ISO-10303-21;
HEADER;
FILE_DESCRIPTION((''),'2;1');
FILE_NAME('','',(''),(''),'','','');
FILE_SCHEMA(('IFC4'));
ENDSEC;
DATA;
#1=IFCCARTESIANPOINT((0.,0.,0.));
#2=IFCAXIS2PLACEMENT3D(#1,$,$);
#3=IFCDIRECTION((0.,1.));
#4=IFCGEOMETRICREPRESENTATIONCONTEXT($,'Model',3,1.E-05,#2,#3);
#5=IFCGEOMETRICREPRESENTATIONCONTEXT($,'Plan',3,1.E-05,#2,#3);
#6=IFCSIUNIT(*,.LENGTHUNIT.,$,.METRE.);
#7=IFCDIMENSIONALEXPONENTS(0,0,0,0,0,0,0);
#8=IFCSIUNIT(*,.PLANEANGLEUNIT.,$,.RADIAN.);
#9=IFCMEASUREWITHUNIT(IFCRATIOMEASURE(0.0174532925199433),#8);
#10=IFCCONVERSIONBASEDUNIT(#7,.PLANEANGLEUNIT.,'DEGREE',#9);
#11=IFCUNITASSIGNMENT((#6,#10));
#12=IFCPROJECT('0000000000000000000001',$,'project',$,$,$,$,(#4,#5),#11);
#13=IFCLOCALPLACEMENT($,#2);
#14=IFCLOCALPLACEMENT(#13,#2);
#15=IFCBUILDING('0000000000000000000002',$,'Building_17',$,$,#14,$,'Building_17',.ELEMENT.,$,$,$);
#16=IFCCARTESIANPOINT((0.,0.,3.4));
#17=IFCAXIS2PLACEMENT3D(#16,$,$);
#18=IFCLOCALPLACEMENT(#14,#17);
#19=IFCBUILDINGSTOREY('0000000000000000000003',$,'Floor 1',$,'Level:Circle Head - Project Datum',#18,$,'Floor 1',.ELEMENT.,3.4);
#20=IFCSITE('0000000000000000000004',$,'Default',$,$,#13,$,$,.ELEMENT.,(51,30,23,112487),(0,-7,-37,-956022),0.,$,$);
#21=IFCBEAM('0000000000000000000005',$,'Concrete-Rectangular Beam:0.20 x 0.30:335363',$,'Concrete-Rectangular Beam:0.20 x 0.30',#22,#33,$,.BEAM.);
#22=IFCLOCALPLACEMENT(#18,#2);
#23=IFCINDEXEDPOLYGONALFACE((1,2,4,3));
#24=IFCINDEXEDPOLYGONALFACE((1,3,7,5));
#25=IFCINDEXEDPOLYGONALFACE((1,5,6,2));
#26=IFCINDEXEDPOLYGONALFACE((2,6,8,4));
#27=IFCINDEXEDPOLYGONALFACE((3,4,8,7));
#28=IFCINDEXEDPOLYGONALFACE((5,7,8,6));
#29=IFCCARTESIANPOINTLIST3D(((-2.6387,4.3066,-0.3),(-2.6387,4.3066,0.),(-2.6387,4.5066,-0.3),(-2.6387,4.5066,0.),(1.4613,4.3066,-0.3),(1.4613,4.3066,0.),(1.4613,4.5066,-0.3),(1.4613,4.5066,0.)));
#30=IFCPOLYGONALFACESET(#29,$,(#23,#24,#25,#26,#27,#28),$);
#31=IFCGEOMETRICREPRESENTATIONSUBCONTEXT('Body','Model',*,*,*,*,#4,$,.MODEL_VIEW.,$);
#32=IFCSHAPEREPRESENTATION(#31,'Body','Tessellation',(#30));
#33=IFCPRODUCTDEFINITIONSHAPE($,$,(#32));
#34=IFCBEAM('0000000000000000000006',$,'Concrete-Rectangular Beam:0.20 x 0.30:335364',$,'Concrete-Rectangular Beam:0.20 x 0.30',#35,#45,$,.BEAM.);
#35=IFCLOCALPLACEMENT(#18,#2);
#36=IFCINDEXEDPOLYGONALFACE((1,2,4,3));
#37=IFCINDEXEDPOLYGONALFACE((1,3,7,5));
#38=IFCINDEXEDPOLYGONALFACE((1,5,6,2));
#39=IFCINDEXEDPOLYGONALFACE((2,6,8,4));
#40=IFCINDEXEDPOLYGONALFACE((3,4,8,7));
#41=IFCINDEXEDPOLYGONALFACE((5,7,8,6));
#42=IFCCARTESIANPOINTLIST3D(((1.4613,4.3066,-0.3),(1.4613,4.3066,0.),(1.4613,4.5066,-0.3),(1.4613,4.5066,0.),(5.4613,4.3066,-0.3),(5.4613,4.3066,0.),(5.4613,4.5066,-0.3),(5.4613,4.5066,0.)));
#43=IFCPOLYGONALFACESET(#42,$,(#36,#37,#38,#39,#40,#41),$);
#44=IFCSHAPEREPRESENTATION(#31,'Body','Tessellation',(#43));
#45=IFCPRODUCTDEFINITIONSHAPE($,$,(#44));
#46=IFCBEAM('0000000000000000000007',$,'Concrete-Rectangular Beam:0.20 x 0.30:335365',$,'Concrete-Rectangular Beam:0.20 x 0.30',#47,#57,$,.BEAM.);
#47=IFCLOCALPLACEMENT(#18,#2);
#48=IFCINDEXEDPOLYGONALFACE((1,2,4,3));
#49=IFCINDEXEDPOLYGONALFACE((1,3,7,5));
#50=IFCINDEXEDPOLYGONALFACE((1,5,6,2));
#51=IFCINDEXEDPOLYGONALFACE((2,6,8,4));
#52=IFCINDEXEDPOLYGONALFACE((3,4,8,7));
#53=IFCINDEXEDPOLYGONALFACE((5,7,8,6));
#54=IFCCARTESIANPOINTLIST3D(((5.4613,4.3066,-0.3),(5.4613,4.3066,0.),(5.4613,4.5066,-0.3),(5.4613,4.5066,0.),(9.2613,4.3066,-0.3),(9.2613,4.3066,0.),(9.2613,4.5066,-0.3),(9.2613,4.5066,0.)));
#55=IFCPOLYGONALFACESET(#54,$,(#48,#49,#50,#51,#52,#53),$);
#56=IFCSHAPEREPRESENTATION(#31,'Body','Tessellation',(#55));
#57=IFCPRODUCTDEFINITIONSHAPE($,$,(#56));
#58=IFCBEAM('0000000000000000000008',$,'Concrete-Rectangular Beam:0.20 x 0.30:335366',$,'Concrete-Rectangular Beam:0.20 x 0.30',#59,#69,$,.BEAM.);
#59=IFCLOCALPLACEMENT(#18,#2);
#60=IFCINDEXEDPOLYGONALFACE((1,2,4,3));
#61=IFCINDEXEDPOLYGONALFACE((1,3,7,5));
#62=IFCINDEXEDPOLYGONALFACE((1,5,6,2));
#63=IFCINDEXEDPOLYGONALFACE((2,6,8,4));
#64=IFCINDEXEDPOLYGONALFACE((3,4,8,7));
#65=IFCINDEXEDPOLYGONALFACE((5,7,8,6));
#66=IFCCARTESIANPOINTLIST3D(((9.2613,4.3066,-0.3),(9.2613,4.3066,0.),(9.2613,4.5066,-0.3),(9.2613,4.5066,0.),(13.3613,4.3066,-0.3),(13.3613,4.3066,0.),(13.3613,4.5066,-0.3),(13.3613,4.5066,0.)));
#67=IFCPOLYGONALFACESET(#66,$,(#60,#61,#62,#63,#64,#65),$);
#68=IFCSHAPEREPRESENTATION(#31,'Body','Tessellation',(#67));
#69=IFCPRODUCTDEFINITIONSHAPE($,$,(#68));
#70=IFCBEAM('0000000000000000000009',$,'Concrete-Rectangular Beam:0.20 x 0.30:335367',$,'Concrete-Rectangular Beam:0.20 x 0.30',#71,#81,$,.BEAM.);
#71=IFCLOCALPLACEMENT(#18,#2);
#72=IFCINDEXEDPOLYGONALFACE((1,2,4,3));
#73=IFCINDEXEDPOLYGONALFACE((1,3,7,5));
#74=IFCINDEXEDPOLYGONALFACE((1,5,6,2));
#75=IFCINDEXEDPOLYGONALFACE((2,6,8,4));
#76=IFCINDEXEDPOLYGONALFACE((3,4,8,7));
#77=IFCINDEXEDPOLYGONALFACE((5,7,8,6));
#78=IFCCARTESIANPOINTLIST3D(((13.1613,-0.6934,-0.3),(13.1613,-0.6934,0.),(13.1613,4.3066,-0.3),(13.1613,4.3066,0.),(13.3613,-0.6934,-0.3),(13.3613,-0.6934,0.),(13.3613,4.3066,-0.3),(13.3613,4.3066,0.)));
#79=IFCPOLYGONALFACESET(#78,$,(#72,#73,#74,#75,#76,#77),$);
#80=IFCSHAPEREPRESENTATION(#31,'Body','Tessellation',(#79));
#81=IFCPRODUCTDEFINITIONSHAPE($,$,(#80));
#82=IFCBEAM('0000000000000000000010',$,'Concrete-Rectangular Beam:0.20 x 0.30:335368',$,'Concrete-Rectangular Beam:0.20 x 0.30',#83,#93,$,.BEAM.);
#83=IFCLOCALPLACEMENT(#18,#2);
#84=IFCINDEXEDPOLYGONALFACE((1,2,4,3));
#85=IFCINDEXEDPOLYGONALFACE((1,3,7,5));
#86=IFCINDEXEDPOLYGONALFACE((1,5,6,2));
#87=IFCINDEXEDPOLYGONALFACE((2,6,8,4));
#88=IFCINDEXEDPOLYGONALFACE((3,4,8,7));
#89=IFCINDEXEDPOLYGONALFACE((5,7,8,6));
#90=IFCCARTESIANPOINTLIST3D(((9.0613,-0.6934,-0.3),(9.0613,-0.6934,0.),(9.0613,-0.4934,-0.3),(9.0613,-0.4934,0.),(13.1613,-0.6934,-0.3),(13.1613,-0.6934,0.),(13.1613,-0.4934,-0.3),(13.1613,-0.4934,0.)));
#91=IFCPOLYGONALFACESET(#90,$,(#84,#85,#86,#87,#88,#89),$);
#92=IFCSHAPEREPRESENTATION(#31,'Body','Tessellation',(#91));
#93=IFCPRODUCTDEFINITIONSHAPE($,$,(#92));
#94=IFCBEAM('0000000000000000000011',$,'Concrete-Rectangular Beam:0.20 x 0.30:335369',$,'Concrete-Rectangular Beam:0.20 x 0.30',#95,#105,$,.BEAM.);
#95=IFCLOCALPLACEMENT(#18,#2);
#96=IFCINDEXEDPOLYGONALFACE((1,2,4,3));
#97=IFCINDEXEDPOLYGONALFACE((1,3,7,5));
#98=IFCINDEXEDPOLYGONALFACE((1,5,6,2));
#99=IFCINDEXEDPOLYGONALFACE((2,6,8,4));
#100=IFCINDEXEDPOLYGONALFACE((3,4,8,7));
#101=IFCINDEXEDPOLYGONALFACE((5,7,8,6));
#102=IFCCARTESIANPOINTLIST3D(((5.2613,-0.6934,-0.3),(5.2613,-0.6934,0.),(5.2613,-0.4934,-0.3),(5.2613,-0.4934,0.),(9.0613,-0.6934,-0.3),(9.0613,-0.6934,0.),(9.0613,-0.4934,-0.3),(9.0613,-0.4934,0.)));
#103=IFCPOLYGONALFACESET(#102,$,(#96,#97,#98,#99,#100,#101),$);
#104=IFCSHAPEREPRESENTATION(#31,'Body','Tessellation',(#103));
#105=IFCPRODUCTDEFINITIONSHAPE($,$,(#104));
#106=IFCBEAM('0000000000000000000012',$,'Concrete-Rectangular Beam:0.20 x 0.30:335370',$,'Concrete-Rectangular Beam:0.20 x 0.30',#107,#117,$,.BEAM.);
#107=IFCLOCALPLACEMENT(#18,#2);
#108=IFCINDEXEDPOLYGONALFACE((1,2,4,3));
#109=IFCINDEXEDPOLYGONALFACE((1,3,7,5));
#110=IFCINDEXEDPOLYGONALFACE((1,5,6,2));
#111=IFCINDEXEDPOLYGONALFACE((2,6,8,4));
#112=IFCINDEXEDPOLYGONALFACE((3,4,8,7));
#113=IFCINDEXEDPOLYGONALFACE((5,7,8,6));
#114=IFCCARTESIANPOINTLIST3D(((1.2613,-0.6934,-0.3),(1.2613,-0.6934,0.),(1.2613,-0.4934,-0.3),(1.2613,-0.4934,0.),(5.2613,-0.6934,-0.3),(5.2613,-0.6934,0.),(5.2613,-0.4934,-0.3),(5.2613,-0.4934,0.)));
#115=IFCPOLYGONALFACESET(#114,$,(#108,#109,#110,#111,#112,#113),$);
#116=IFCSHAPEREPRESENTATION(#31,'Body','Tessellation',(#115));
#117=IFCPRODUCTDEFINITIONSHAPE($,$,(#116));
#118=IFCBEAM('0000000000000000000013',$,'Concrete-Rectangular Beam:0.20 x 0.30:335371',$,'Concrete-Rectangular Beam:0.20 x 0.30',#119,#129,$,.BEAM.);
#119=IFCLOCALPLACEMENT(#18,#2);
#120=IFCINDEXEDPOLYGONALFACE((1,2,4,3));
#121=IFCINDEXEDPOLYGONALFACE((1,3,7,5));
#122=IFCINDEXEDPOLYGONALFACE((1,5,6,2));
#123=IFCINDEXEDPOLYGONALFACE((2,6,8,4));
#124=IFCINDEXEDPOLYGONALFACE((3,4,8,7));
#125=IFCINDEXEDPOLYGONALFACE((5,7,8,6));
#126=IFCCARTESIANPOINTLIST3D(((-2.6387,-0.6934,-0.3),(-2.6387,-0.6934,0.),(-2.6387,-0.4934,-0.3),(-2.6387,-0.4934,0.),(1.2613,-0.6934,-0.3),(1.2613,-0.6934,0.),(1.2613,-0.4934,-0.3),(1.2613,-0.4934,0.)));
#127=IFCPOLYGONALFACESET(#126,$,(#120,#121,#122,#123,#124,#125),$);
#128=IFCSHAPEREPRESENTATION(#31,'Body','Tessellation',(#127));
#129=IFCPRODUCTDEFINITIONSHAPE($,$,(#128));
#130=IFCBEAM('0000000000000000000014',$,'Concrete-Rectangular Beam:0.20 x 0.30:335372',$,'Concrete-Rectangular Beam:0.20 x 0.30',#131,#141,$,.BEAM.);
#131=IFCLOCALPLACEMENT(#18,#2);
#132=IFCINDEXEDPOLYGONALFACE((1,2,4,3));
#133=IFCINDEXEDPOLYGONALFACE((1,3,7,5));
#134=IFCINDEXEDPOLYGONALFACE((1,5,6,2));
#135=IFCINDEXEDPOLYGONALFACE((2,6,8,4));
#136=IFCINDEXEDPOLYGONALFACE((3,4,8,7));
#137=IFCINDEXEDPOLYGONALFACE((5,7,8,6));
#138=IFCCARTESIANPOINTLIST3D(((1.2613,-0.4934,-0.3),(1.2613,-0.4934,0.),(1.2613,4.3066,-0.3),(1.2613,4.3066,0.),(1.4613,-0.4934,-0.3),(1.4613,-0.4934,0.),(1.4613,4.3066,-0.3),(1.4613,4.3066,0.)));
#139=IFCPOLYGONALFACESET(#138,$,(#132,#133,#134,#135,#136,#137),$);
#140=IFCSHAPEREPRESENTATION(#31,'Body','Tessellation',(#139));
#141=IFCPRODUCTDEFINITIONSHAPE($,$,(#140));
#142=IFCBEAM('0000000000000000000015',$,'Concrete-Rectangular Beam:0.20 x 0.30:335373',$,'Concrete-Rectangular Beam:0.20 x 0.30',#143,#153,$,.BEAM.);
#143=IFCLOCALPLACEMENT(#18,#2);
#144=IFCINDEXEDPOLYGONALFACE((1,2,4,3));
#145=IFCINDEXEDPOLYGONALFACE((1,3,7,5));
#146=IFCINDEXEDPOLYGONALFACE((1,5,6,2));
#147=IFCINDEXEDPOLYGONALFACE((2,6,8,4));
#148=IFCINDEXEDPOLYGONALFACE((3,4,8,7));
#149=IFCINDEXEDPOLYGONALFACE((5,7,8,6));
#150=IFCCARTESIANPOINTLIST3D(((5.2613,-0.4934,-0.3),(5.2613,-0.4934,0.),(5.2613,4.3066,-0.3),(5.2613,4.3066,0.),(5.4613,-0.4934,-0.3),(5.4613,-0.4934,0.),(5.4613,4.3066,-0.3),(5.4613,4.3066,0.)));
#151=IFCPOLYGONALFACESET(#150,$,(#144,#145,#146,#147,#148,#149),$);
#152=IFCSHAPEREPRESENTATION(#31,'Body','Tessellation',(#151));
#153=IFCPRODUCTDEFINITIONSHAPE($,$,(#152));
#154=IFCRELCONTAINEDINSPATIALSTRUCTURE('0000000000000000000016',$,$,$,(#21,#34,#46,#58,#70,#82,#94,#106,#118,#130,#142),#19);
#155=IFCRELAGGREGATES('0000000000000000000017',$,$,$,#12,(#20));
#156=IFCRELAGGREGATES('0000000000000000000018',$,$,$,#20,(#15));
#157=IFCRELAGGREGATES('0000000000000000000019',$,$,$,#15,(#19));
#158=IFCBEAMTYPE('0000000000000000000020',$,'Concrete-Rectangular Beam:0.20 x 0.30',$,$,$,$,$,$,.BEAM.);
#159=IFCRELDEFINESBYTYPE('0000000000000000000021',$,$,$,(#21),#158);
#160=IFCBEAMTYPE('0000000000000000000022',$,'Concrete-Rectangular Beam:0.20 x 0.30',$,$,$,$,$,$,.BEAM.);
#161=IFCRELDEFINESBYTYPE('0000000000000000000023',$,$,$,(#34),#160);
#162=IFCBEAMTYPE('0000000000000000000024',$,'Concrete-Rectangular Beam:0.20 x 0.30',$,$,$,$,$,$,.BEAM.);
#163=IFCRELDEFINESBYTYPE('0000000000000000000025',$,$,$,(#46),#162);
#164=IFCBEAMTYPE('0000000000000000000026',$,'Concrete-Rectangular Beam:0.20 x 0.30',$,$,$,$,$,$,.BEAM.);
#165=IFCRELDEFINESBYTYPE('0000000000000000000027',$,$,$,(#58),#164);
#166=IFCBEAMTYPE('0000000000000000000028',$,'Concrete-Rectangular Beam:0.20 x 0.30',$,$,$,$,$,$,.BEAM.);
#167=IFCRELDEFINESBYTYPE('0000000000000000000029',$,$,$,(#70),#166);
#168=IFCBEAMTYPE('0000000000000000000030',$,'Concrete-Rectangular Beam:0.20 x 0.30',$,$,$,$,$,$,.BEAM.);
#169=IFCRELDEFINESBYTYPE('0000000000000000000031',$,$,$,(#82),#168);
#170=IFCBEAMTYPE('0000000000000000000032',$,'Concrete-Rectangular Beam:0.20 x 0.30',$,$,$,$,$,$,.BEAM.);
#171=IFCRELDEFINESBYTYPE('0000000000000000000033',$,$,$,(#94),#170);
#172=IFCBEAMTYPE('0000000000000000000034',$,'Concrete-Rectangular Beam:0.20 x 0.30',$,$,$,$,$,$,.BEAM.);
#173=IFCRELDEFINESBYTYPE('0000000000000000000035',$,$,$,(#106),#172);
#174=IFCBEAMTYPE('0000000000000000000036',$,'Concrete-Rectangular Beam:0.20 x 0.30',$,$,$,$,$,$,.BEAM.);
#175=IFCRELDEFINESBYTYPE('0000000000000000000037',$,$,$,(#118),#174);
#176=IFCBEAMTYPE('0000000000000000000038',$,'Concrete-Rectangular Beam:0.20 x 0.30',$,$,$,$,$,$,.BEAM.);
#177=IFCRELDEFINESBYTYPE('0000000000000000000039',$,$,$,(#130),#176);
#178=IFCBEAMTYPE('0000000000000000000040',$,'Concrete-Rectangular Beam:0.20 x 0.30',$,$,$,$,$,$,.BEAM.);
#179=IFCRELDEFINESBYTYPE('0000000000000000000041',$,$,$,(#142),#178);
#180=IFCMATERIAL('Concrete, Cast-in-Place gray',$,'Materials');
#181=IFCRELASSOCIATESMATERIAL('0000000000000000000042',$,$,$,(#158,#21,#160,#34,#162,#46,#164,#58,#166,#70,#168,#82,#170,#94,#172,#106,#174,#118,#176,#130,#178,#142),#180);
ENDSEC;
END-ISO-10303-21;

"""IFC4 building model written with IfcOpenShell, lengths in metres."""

from ifc_helpers import new_model, entity, si_unit, converted_unit, direction, frame, origin, place, context, subcontext, project, spatial, indexed_curve, outline, extrude, source, transform, mapped, material, type_object, type_shapes, element, save


model = new_model("IFC4")

# Units and contexts
model_context = context("Model", 3, precision=1e-05, world=origin(), true_north=direction((0.0, 1.0)))
plan_context = context("Plan", 3, precision=1e-05, world=origin(), true_north=direction((0.0, 1.0)))
body_context = subcontext(model_context, "Body", "Model", "MODEL_VIEW")
ifc_project = project(units=[si_unit("LENGTHUNIT", "METRE"), converted_unit("PLANEANGLEUNIT", "DEGREE", entity("IfcRatioMeasure", 0.0174532925199433), si_unit("PLANEANGLEUNIT", "RADIAN"), dimensions=[0, 0, 0, 0, 0, 0, 0])], contexts=[model_context, plan_context])

# Site, building, storey
site_placement = place(None, origin())
site = spatial("IfcSite", under=ifc_project, at=site_placement, Name="Default", CompositionType="ELEMENT", RefLatitude=(51, 30, 23, 112487), RefLongitude=(0, -7, -37, -956022), RefElevation=0.0)
building_placement = place(site_placement, origin())
building = spatial("IfcBuilding", under=site, at=building_placement, Name="Building_17", LongName="Building_17", CompositionType="ELEMENT")
storey_placement = place(building_placement, frame((0.0, 0.0, 3.4)))
storey = spatial("IfcBuildingStorey", under=building, at=storey_placement, Name="Floor 1", ObjectType="Level:Circle Head - Project Datum", LongName="Floor 1", CompositionType="ELEMENT", Elevation=3.4)

# Beams
ifc_material = material(Name="Concrete, Cast-in-Place gray", Category="Materials")
beam_type_1 = type_object("IfcBeamType", Name="Concrete-Rectangular Beam:0.20 x 0.30", PredefinedType="BEAM", material=ifc_material)
shared_shape_1 = source(origin(), body_context, "Body", "SweptSolid", [
    extrude(outline(indexed_curve([(-0.15, -0.1), (0.15, -0.1), (0.15, 0.1), (-0.15, 0.1), (-0.15, -0.1)], self_intersect=False)), frame((-2.6387, 4.4066, 3.25), z_axis=(1.0, 0.0, 0.0), x_axis=(0.0, 0.0, -1.0)), (0.0, 0.0, 1.0), 4.1),
])
type_shapes(beam_type_1, [shared_shape_1])
beam_1_placement = place(storey_placement, frame((0.0, 0.0, -3.4)))
element("IfcBeam", 1, at=beam_1_placement, inside=storey, type_object=beam_type_1, material=ifc_material, Name="Concrete-Rectangular Beam:0.20 x 0.30:335363", ObjectType="Concrete-Rectangular Beam:0.20 x 0.30", PredefinedType="BEAM", context=body_context, shape_type="MappedRepresentation", body=[
    mapped(shared_shape_1, transform((0.0, 0.0, 0.0), scale=1.0)),
])
beam_type_2 = type_object("IfcBeamType", Name="Concrete-Rectangular Beam:0.20 x 0.30", PredefinedType="BEAM", material=ifc_material)
shared_shape_2 = source(origin(), body_context, "Body", "SweptSolid", [
    extrude(outline(indexed_curve([(-0.15, -0.1), (0.15, -0.1), (0.15, 0.1), (-0.15, 0.1), (-0.15, -0.1)], self_intersect=False)), frame((1.4613, 4.4066, 3.25), z_axis=(1.0, 0.0, 0.0), x_axis=(0.0, 0.0, -1.0)), (0.0, 0.0, 1.0), 4.0),
])
type_shapes(beam_type_2, [shared_shape_2])
beam_2_placement = place(storey_placement, frame((0.0, 0.0, -3.4)))
element("IfcBeam", 2, at=beam_2_placement, inside=storey, type_object=beam_type_2, material=ifc_material, Name="Concrete-Rectangular Beam:0.20 x 0.30:335364", ObjectType="Concrete-Rectangular Beam:0.20 x 0.30", PredefinedType="BEAM", context=body_context, shape_type="MappedRepresentation", body=[
    mapped(shared_shape_2, transform((0.0, 0.0, 0.0), scale=1.0)),
])
beam_type_3 = type_object("IfcBeamType", Name="Concrete-Rectangular Beam:0.20 x 0.30", PredefinedType="BEAM", material=ifc_material)
shared_shape_3 = source(origin(), body_context, "Body", "SweptSolid", [
    extrude(outline(indexed_curve([(-0.15, -0.1), (0.15, -0.1), (0.15, 0.1), (-0.15, 0.1), (-0.15, -0.1)], self_intersect=False)), frame((5.4613, 4.4066, 3.25), z_axis=(1.0, 0.0, 0.0), x_axis=(0.0, 0.0, -1.0)), (0.0, 0.0, 1.0), 3.8),
])
type_shapes(beam_type_3, [shared_shape_3])
beam_3_placement = place(storey_placement, frame((0.0, 0.0, -3.4)))
element("IfcBeam", 3, at=beam_3_placement, inside=storey, type_object=beam_type_3, material=ifc_material, Name="Concrete-Rectangular Beam:0.20 x 0.30:335365", ObjectType="Concrete-Rectangular Beam:0.20 x 0.30", PredefinedType="BEAM", context=body_context, shape_type="MappedRepresentation", body=[
    mapped(shared_shape_3, transform((0.0, 0.0, 0.0), scale=1.0)),
])
beam_type_4 = type_object("IfcBeamType", Name="Concrete-Rectangular Beam:0.20 x 0.30", PredefinedType="BEAM", material=ifc_material)
shared_shape_4 = source(origin(), body_context, "Body", "SweptSolid", [
    extrude(outline(indexed_curve([(-0.15, -0.1), (0.15, -0.1), (0.15, 0.1), (-0.15, 0.1), (-0.15, -0.1)], self_intersect=False)), frame((9.2613, 4.4066, 3.25), z_axis=(1.0, 0.0, 0.0), x_axis=(0.0, 0.0, -1.0)), (0.0, 0.0, 1.0), 4.1),
])
type_shapes(beam_type_4, [shared_shape_4])
beam_4_placement = place(storey_placement, frame((0.0, 0.0, -3.4)))
element("IfcBeam", 4, at=beam_4_placement, inside=storey, type_object=beam_type_4, material=ifc_material, Name="Concrete-Rectangular Beam:0.20 x 0.30:335366", ObjectType="Concrete-Rectangular Beam:0.20 x 0.30", PredefinedType="BEAM", context=body_context, shape_type="MappedRepresentation", body=[
    mapped(shared_shape_4, transform((0.0, 0.0, 0.0), scale=1.0)),
])
beam_type_5 = type_object("IfcBeamType", Name="Concrete-Rectangular Beam:0.20 x 0.30", PredefinedType="BEAM", material=ifc_material)
shared_shape_5 = source(origin(), body_context, "Body", "SweptSolid", [
    extrude(outline(indexed_curve([(-0.1, -0.15), (0.1, -0.15), (0.1, 0.15), (-0.1, 0.15), (-0.1, -0.15)], self_intersect=False)), frame((13.2613, 4.3066, 3.25), z_axis=(0.0, -1.0, 0.0), x_axis=(-1.0, 0.0, 0.0)), (0.0, 0.0, 1.0), 5.0),
])
type_shapes(beam_type_5, [shared_shape_5])
beam_5_placement = place(storey_placement, frame((0.0, 0.0, -3.4)))
element("IfcBeam", 5, at=beam_5_placement, inside=storey, type_object=beam_type_5, material=ifc_material, Name="Concrete-Rectangular Beam:0.20 x 0.30:335367", ObjectType="Concrete-Rectangular Beam:0.20 x 0.30", PredefinedType="BEAM", context=body_context, shape_type="MappedRepresentation", body=[
    mapped(shared_shape_5, transform((0.0, 0.0, 0.0), scale=1.0)),
])
beam_type_6 = type_object("IfcBeamType", Name="Concrete-Rectangular Beam:0.20 x 0.30", PredefinedType="BEAM", material=ifc_material)
shared_shape_6 = source(origin(), body_context, "Body", "SweptSolid", [
    extrude(outline(indexed_curve([(-0.15, -0.1), (0.15, -0.1), (0.15, 0.1), (-0.15, 0.1), (-0.15, -0.1)], self_intersect=False)), frame((13.1613, -0.5934, 3.25), z_axis=(-1.0, 0.0, 0.0), x_axis=(0.0, 0.0, -1.0)), (0.0, 0.0, 1.0), 4.1),
])
type_shapes(beam_type_6, [shared_shape_6])
beam_6_placement = place(storey_placement, frame((0.0, 0.0, -3.4)))
element("IfcBeam", 6, at=beam_6_placement, inside=storey, type_object=beam_type_6, material=ifc_material, Name="Concrete-Rectangular Beam:0.20 x 0.30:335368", ObjectType="Concrete-Rectangular Beam:0.20 x 0.30", PredefinedType="BEAM", context=body_context, shape_type="MappedRepresentation", body=[
    mapped(shared_shape_6, transform((0.0, 0.0, 0.0), scale=1.0)),
])
beam_type_7 = type_object("IfcBeamType", Name="Concrete-Rectangular Beam:0.20 x 0.30", PredefinedType="BEAM", material=ifc_material)
shared_shape_7 = source(origin(), body_context, "Body", "SweptSolid", [
    extrude(outline(indexed_curve([(-0.15, -0.1), (0.15, -0.1), (0.15, 0.1), (-0.15, 0.1), (-0.15, -0.1)], self_intersect=False)), frame((9.0613, -0.5934, 3.25), z_axis=(-1.0, 0.0, 0.0), x_axis=(0.0, 0.0, -1.0)), (0.0, 0.0, 1.0), 3.8),
])
type_shapes(beam_type_7, [shared_shape_7])
beam_7_placement = place(storey_placement, frame((0.0, 0.0, -3.4)))
element("IfcBeam", 7, at=beam_7_placement, inside=storey, type_object=beam_type_7, material=ifc_material, Name="Concrete-Rectangular Beam:0.20 x 0.30:335369", ObjectType="Concrete-Rectangular Beam:0.20 x 0.30", PredefinedType="BEAM", context=body_context, shape_type="MappedRepresentation", body=[
    mapped(shared_shape_7, transform((0.0, 0.0, 0.0), scale=1.0)),
])
beam_type_8 = type_object("IfcBeamType", Name="Concrete-Rectangular Beam:0.20 x 0.30", PredefinedType="BEAM", material=ifc_material)
shared_shape_8 = source(origin(), body_context, "Body", "SweptSolid", [
    extrude(outline(indexed_curve([(-0.15, -0.1), (0.15, -0.1), (0.15, 0.1), (-0.15, 0.1), (-0.15, -0.1)], self_intersect=False)), frame((5.2613, -0.5934, 3.25), z_axis=(-1.0, 0.0, 0.0), x_axis=(0.0, 0.0, -1.0)), (0.0, 0.0, 1.0), 4.0),
])
type_shapes(beam_type_8, [shared_shape_8])
beam_8_placement = place(storey_placement, frame((0.0, 0.0, -3.4)))
element("IfcBeam", 8, at=beam_8_placement, inside=storey, type_object=beam_type_8, material=ifc_material, Name="Concrete-Rectangular Beam:0.20 x 0.30:335370", ObjectType="Concrete-Rectangular Beam:0.20 x 0.30", PredefinedType="BEAM", context=body_context, shape_type="MappedRepresentation", body=[
    mapped(shared_shape_8, transform((0.0, 0.0, 0.0), scale=1.0)),
])
beam_type_9 = type_object("IfcBeamType", Name="Concrete-Rectangular Beam:0.20 x 0.30", PredefinedType="BEAM", material=ifc_material)
shared_shape_9 = source(origin(), body_context, "Body", "SweptSolid", [
    extrude(outline(indexed_curve([(-0.15, -0.1), (0.15, -0.1), (0.15, 0.1), (-0.15, 0.1), (-0.15, -0.1)], self_intersect=False)), frame((1.2613, -0.5934, 3.25), z_axis=(-1.0, 0.0, 0.0), x_axis=(0.0, 0.0, -1.0)), (0.0, 0.0, 1.0), 3.9),
])
type_shapes(beam_type_9, [shared_shape_9])
beam_9_placement = place(storey_placement, frame((0.0, 0.0, -3.4)))
element("IfcBeam", 9, at=beam_9_placement, inside=storey, type_object=beam_type_9, material=ifc_material, Name="Concrete-Rectangular Beam:0.20 x 0.30:335371", ObjectType="Concrete-Rectangular Beam:0.20 x 0.30", PredefinedType="BEAM", context=body_context, shape_type="MappedRepresentation", body=[
    mapped(shared_shape_9, transform((0.0, 0.0, 0.0), scale=1.0)),
])
beam_type_10 = type_object("IfcBeamType", Name="Concrete-Rectangular Beam:0.20 x 0.30", PredefinedType="BEAM", material=ifc_material)
shared_shape_10 = source(origin(), body_context, "Body", "SweptSolid", [
    extrude(outline(indexed_curve([(-0.1, -0.15), (0.1, -0.15), (0.1, 0.15), (-0.1, 0.15), (-0.1, -0.15)], self_intersect=False)), frame((1.3613, -0.4934, 3.25), z_axis=(0.0, 1.0, 0.0), x_axis=(-1.0, 0.0, 0.0)), (0.0, 0.0, 1.0), 4.8),
])
type_shapes(beam_type_10, [shared_shape_10])
beam_10_placement = place(storey_placement, frame((0.0, 0.0, -3.4)))
element("IfcBeam", 10, at=beam_10_placement, inside=storey, type_object=beam_type_10, material=ifc_material, Name="Concrete-Rectangular Beam:0.20 x 0.30:335372", ObjectType="Concrete-Rectangular Beam:0.20 x 0.30", PredefinedType="BEAM", context=body_context, shape_type="MappedRepresentation", body=[
    mapped(shared_shape_10, transform((0.0, 0.0, 0.0), scale=1.0)),
])
beam_type_11 = type_object("IfcBeamType", Name="Concrete-Rectangular Beam:0.20 x 0.30", PredefinedType="BEAM", material=ifc_material)
shared_shape_11 = source(origin(), body_context, "Body", "SweptSolid", [
    extrude(outline(indexed_curve([(-0.1, -0.15), (0.1, -0.15), (0.1, 0.15), (-0.1, 0.15), (-0.1, -0.15)], self_intersect=False)), frame((5.3613, 4.3066, 3.25), z_axis=(0.0, -1.0, 0.0), x_axis=(-1.0, 0.0, 0.0)), (0.0, 0.0, 1.0), 4.8),
])
type_shapes(beam_type_11, [shared_shape_11])
beam_11_placement = place(storey_placement, frame((0.0, 0.0, -3.4)))
element("IfcBeam", 11, at=beam_11_placement, inside=storey, type_object=beam_type_11, material=ifc_material, Name="Concrete-Rectangular Beam:0.20 x 0.30:335373", ObjectType="Concrete-Rectangular Beam:0.20 x 0.30", PredefinedType="BEAM", context=body_context, shape_type="MappedRepresentation", body=[
    mapped(shared_shape_11, transform((0.0, 0.0, 0.0), scale=1.0)),
])

save(model, "model.ifc")
